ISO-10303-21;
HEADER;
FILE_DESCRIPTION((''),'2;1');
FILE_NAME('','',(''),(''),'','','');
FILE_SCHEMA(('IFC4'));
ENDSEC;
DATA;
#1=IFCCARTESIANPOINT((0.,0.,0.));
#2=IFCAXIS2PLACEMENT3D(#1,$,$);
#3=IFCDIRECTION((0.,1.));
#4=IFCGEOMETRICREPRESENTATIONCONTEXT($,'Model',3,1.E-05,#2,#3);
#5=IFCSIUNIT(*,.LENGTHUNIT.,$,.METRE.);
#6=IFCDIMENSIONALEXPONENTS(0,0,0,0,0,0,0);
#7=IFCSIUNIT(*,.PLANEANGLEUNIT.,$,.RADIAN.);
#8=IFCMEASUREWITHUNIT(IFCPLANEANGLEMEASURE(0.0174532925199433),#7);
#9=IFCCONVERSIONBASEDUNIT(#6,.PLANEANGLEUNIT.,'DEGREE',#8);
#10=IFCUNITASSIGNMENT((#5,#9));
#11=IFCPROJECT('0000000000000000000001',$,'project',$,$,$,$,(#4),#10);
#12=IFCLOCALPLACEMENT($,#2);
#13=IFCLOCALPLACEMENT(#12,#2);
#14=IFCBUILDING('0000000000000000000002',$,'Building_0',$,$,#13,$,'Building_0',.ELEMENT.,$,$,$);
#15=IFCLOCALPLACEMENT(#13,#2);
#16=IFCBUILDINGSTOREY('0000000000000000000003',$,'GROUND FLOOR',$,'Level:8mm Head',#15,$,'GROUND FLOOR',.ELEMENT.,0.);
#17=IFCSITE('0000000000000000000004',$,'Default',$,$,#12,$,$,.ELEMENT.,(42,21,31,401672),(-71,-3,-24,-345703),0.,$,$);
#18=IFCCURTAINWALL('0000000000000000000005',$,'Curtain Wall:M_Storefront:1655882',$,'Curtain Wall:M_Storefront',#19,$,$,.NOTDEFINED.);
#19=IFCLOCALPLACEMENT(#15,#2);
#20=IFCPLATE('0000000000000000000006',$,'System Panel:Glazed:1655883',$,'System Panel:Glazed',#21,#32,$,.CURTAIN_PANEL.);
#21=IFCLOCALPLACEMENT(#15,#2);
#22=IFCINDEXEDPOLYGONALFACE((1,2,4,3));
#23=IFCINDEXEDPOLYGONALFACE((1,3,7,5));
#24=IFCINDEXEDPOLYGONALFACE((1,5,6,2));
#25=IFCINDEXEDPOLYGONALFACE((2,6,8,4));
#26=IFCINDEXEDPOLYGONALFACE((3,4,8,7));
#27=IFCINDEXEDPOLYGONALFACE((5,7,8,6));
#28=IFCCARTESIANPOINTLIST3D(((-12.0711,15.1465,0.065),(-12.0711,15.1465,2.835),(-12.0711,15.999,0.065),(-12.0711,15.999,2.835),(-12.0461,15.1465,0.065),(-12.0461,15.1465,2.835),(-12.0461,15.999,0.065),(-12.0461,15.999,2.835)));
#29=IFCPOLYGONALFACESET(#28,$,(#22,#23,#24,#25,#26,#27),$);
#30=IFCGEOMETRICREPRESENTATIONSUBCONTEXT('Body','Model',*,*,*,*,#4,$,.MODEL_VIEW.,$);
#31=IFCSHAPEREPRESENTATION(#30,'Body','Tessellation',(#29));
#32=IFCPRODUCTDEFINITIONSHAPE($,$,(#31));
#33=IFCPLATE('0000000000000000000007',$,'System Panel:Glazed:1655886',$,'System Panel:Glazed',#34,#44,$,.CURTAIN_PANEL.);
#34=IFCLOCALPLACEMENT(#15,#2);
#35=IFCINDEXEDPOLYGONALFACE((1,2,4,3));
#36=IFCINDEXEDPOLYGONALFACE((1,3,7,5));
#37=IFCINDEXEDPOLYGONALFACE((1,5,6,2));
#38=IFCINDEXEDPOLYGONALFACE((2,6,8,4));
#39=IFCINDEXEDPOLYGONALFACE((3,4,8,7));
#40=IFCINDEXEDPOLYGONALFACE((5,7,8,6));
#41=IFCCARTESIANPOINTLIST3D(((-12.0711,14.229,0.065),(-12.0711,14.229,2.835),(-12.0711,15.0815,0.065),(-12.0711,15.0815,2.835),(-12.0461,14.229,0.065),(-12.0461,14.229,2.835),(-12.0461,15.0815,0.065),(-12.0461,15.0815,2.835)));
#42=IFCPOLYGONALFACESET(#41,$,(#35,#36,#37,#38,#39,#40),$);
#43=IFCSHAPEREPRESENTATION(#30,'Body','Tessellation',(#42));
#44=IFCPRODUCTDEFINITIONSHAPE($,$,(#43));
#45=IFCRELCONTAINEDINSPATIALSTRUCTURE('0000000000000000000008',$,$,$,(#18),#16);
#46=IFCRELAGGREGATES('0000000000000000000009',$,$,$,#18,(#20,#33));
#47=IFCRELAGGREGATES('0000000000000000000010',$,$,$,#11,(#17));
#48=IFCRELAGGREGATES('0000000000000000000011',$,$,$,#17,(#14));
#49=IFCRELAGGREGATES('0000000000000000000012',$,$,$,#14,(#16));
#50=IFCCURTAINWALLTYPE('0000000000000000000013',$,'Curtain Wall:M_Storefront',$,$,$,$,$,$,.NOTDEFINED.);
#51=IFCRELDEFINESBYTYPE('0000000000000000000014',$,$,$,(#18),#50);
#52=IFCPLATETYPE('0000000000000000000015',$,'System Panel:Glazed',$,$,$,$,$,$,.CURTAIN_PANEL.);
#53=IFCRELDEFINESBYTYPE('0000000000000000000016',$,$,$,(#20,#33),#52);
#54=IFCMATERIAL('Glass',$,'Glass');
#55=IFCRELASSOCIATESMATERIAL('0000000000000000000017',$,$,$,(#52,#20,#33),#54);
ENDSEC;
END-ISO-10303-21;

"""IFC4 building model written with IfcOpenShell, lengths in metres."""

from ifc_helpers import new_model, entity, si_unit, converted_unit, direction, frame, origin, place, context, subcontext, project, spatial, indexed_curve, outline, extrude, source, transform, mapped, material, type_object, type_shapes, element, aggregate, save


model = new_model("IFC4")

# Units and contexts
model_context = context("Model", 3, precision=1e-05, world=origin(), true_north=direction((0.0, 1.0)))
body_context = subcontext(model_context, "Body", "Model", "MODEL_VIEW")
ifc_project = project(units=[si_unit("LENGTHUNIT", "METRE"), converted_unit("PLANEANGLEUNIT", "DEGREE", entity("IfcPlaneAngleMeasure", 0.0174532925199433), si_unit("PLANEANGLEUNIT", "RADIAN"), dimensions=[0, 0, 0, 0, 0, 0, 0])], contexts=[model_context])

# Site, building, storey
site_placement = place(None, origin())
site = spatial("IfcSite", under=ifc_project, at=site_placement, Name="Default", CompositionType="ELEMENT", RefLatitude=(42, 21, 31, 401672), RefLongitude=(-71, -3, -24, -345703), RefElevation=0.0)
building_placement = place(site_placement, origin())
building = spatial("IfcBuilding", under=site, at=building_placement, Name="Building_0", LongName="Building_0", CompositionType="ELEMENT")
storey_placement = place(building_placement, origin())
storey = spatial("IfcBuildingStorey", under=building, at=storey_placement, Name="GROUND FLOOR", ObjectType="Level:8mm Head", LongName="GROUND FLOOR", CompositionType="ELEMENT", Elevation=0.0)

# Curtain wall
curtain_wall_type = type_object("IfcCurtainWallType", Name="Curtain Wall:M_Storefront", PredefinedType="NOTDEFINED")
curtain_wall_1_placement = place(storey_placement, origin())
curtain_wall_1 = element("IfcCurtainWall", 1, at=curtain_wall_1_placement, inside=storey, type_object=curtain_wall_type, Name="Curtain Wall:M_Storefront:1655882", ObjectType="Curtain Wall:M_Storefront", PredefinedType="NOTDEFINED")

# Plates
ifc_material_1 = material(Name="Glass", Category="Glass")
plate_type_1 = type_object("IfcPlateType", Name="System Panel:Glazed", PredefinedType="CURTAIN_PANEL", material=ifc_material_1)
shared_shape_1 = source(origin(), body_context, "Body", "SweptSolid", [
    extrude(outline(indexed_curve([(-0.0125, -0.4262), (0.0125, -0.4262), (0.0125, 0.4262), (-0.0125, 0.4262), (-0.0125, -0.4262)], self_intersect=False)), frame((0.0, 0.037, 0.0), z_axis=(0.0, 0.0, 1.0), x_axis=(0.0, 1.0, 0.0)), (0.0, 0.0, 1.0), 2.77),
])
type_shapes(plate_type_1, [shared_shape_1])
plate_1_placement = place(curtain_wall_1_placement, frame((-12.0956, 15.5727, 0.065), z_axis=(0.0, 0.0, 1.0), x_axis=(0.0, -1.0, 0.0)))
plate_1 = element("IfcPlate", 2, at=plate_1_placement, type_object=plate_type_1, material=ifc_material_1, Name="System Panel:Glazed:1655883", ObjectType="System Panel:Glazed", PredefinedType="CURTAIN_PANEL", context=body_context, shape_type="MappedRepresentation", body=[
    mapped(shared_shape_1, transform((0.0, 0.0, 0.0), scale=1.0)),
])
plate_2_placement = place(curtain_wall_1_placement, frame((-12.0956, 14.6552, 0.065), z_axis=(0.0, 0.0, 1.0), x_axis=(0.0, -1.0, 0.0)))
plate_2 = element("IfcPlate", 3, at=plate_2_placement, type_object=plate_type_1, material=ifc_material_1, Name="System Panel:Glazed:1655886", ObjectType="System Panel:Glazed", PredefinedType="CURTAIN_PANEL", context=body_context, shape_type="MappedRepresentation", body=[
    mapped(shared_shape_1, transform((0.0, 0.0, 0.0), scale=1.0)),
])
aggregate(curtain_wall_1, [plate_1, plate_2])

save(model, "model.ifc")
